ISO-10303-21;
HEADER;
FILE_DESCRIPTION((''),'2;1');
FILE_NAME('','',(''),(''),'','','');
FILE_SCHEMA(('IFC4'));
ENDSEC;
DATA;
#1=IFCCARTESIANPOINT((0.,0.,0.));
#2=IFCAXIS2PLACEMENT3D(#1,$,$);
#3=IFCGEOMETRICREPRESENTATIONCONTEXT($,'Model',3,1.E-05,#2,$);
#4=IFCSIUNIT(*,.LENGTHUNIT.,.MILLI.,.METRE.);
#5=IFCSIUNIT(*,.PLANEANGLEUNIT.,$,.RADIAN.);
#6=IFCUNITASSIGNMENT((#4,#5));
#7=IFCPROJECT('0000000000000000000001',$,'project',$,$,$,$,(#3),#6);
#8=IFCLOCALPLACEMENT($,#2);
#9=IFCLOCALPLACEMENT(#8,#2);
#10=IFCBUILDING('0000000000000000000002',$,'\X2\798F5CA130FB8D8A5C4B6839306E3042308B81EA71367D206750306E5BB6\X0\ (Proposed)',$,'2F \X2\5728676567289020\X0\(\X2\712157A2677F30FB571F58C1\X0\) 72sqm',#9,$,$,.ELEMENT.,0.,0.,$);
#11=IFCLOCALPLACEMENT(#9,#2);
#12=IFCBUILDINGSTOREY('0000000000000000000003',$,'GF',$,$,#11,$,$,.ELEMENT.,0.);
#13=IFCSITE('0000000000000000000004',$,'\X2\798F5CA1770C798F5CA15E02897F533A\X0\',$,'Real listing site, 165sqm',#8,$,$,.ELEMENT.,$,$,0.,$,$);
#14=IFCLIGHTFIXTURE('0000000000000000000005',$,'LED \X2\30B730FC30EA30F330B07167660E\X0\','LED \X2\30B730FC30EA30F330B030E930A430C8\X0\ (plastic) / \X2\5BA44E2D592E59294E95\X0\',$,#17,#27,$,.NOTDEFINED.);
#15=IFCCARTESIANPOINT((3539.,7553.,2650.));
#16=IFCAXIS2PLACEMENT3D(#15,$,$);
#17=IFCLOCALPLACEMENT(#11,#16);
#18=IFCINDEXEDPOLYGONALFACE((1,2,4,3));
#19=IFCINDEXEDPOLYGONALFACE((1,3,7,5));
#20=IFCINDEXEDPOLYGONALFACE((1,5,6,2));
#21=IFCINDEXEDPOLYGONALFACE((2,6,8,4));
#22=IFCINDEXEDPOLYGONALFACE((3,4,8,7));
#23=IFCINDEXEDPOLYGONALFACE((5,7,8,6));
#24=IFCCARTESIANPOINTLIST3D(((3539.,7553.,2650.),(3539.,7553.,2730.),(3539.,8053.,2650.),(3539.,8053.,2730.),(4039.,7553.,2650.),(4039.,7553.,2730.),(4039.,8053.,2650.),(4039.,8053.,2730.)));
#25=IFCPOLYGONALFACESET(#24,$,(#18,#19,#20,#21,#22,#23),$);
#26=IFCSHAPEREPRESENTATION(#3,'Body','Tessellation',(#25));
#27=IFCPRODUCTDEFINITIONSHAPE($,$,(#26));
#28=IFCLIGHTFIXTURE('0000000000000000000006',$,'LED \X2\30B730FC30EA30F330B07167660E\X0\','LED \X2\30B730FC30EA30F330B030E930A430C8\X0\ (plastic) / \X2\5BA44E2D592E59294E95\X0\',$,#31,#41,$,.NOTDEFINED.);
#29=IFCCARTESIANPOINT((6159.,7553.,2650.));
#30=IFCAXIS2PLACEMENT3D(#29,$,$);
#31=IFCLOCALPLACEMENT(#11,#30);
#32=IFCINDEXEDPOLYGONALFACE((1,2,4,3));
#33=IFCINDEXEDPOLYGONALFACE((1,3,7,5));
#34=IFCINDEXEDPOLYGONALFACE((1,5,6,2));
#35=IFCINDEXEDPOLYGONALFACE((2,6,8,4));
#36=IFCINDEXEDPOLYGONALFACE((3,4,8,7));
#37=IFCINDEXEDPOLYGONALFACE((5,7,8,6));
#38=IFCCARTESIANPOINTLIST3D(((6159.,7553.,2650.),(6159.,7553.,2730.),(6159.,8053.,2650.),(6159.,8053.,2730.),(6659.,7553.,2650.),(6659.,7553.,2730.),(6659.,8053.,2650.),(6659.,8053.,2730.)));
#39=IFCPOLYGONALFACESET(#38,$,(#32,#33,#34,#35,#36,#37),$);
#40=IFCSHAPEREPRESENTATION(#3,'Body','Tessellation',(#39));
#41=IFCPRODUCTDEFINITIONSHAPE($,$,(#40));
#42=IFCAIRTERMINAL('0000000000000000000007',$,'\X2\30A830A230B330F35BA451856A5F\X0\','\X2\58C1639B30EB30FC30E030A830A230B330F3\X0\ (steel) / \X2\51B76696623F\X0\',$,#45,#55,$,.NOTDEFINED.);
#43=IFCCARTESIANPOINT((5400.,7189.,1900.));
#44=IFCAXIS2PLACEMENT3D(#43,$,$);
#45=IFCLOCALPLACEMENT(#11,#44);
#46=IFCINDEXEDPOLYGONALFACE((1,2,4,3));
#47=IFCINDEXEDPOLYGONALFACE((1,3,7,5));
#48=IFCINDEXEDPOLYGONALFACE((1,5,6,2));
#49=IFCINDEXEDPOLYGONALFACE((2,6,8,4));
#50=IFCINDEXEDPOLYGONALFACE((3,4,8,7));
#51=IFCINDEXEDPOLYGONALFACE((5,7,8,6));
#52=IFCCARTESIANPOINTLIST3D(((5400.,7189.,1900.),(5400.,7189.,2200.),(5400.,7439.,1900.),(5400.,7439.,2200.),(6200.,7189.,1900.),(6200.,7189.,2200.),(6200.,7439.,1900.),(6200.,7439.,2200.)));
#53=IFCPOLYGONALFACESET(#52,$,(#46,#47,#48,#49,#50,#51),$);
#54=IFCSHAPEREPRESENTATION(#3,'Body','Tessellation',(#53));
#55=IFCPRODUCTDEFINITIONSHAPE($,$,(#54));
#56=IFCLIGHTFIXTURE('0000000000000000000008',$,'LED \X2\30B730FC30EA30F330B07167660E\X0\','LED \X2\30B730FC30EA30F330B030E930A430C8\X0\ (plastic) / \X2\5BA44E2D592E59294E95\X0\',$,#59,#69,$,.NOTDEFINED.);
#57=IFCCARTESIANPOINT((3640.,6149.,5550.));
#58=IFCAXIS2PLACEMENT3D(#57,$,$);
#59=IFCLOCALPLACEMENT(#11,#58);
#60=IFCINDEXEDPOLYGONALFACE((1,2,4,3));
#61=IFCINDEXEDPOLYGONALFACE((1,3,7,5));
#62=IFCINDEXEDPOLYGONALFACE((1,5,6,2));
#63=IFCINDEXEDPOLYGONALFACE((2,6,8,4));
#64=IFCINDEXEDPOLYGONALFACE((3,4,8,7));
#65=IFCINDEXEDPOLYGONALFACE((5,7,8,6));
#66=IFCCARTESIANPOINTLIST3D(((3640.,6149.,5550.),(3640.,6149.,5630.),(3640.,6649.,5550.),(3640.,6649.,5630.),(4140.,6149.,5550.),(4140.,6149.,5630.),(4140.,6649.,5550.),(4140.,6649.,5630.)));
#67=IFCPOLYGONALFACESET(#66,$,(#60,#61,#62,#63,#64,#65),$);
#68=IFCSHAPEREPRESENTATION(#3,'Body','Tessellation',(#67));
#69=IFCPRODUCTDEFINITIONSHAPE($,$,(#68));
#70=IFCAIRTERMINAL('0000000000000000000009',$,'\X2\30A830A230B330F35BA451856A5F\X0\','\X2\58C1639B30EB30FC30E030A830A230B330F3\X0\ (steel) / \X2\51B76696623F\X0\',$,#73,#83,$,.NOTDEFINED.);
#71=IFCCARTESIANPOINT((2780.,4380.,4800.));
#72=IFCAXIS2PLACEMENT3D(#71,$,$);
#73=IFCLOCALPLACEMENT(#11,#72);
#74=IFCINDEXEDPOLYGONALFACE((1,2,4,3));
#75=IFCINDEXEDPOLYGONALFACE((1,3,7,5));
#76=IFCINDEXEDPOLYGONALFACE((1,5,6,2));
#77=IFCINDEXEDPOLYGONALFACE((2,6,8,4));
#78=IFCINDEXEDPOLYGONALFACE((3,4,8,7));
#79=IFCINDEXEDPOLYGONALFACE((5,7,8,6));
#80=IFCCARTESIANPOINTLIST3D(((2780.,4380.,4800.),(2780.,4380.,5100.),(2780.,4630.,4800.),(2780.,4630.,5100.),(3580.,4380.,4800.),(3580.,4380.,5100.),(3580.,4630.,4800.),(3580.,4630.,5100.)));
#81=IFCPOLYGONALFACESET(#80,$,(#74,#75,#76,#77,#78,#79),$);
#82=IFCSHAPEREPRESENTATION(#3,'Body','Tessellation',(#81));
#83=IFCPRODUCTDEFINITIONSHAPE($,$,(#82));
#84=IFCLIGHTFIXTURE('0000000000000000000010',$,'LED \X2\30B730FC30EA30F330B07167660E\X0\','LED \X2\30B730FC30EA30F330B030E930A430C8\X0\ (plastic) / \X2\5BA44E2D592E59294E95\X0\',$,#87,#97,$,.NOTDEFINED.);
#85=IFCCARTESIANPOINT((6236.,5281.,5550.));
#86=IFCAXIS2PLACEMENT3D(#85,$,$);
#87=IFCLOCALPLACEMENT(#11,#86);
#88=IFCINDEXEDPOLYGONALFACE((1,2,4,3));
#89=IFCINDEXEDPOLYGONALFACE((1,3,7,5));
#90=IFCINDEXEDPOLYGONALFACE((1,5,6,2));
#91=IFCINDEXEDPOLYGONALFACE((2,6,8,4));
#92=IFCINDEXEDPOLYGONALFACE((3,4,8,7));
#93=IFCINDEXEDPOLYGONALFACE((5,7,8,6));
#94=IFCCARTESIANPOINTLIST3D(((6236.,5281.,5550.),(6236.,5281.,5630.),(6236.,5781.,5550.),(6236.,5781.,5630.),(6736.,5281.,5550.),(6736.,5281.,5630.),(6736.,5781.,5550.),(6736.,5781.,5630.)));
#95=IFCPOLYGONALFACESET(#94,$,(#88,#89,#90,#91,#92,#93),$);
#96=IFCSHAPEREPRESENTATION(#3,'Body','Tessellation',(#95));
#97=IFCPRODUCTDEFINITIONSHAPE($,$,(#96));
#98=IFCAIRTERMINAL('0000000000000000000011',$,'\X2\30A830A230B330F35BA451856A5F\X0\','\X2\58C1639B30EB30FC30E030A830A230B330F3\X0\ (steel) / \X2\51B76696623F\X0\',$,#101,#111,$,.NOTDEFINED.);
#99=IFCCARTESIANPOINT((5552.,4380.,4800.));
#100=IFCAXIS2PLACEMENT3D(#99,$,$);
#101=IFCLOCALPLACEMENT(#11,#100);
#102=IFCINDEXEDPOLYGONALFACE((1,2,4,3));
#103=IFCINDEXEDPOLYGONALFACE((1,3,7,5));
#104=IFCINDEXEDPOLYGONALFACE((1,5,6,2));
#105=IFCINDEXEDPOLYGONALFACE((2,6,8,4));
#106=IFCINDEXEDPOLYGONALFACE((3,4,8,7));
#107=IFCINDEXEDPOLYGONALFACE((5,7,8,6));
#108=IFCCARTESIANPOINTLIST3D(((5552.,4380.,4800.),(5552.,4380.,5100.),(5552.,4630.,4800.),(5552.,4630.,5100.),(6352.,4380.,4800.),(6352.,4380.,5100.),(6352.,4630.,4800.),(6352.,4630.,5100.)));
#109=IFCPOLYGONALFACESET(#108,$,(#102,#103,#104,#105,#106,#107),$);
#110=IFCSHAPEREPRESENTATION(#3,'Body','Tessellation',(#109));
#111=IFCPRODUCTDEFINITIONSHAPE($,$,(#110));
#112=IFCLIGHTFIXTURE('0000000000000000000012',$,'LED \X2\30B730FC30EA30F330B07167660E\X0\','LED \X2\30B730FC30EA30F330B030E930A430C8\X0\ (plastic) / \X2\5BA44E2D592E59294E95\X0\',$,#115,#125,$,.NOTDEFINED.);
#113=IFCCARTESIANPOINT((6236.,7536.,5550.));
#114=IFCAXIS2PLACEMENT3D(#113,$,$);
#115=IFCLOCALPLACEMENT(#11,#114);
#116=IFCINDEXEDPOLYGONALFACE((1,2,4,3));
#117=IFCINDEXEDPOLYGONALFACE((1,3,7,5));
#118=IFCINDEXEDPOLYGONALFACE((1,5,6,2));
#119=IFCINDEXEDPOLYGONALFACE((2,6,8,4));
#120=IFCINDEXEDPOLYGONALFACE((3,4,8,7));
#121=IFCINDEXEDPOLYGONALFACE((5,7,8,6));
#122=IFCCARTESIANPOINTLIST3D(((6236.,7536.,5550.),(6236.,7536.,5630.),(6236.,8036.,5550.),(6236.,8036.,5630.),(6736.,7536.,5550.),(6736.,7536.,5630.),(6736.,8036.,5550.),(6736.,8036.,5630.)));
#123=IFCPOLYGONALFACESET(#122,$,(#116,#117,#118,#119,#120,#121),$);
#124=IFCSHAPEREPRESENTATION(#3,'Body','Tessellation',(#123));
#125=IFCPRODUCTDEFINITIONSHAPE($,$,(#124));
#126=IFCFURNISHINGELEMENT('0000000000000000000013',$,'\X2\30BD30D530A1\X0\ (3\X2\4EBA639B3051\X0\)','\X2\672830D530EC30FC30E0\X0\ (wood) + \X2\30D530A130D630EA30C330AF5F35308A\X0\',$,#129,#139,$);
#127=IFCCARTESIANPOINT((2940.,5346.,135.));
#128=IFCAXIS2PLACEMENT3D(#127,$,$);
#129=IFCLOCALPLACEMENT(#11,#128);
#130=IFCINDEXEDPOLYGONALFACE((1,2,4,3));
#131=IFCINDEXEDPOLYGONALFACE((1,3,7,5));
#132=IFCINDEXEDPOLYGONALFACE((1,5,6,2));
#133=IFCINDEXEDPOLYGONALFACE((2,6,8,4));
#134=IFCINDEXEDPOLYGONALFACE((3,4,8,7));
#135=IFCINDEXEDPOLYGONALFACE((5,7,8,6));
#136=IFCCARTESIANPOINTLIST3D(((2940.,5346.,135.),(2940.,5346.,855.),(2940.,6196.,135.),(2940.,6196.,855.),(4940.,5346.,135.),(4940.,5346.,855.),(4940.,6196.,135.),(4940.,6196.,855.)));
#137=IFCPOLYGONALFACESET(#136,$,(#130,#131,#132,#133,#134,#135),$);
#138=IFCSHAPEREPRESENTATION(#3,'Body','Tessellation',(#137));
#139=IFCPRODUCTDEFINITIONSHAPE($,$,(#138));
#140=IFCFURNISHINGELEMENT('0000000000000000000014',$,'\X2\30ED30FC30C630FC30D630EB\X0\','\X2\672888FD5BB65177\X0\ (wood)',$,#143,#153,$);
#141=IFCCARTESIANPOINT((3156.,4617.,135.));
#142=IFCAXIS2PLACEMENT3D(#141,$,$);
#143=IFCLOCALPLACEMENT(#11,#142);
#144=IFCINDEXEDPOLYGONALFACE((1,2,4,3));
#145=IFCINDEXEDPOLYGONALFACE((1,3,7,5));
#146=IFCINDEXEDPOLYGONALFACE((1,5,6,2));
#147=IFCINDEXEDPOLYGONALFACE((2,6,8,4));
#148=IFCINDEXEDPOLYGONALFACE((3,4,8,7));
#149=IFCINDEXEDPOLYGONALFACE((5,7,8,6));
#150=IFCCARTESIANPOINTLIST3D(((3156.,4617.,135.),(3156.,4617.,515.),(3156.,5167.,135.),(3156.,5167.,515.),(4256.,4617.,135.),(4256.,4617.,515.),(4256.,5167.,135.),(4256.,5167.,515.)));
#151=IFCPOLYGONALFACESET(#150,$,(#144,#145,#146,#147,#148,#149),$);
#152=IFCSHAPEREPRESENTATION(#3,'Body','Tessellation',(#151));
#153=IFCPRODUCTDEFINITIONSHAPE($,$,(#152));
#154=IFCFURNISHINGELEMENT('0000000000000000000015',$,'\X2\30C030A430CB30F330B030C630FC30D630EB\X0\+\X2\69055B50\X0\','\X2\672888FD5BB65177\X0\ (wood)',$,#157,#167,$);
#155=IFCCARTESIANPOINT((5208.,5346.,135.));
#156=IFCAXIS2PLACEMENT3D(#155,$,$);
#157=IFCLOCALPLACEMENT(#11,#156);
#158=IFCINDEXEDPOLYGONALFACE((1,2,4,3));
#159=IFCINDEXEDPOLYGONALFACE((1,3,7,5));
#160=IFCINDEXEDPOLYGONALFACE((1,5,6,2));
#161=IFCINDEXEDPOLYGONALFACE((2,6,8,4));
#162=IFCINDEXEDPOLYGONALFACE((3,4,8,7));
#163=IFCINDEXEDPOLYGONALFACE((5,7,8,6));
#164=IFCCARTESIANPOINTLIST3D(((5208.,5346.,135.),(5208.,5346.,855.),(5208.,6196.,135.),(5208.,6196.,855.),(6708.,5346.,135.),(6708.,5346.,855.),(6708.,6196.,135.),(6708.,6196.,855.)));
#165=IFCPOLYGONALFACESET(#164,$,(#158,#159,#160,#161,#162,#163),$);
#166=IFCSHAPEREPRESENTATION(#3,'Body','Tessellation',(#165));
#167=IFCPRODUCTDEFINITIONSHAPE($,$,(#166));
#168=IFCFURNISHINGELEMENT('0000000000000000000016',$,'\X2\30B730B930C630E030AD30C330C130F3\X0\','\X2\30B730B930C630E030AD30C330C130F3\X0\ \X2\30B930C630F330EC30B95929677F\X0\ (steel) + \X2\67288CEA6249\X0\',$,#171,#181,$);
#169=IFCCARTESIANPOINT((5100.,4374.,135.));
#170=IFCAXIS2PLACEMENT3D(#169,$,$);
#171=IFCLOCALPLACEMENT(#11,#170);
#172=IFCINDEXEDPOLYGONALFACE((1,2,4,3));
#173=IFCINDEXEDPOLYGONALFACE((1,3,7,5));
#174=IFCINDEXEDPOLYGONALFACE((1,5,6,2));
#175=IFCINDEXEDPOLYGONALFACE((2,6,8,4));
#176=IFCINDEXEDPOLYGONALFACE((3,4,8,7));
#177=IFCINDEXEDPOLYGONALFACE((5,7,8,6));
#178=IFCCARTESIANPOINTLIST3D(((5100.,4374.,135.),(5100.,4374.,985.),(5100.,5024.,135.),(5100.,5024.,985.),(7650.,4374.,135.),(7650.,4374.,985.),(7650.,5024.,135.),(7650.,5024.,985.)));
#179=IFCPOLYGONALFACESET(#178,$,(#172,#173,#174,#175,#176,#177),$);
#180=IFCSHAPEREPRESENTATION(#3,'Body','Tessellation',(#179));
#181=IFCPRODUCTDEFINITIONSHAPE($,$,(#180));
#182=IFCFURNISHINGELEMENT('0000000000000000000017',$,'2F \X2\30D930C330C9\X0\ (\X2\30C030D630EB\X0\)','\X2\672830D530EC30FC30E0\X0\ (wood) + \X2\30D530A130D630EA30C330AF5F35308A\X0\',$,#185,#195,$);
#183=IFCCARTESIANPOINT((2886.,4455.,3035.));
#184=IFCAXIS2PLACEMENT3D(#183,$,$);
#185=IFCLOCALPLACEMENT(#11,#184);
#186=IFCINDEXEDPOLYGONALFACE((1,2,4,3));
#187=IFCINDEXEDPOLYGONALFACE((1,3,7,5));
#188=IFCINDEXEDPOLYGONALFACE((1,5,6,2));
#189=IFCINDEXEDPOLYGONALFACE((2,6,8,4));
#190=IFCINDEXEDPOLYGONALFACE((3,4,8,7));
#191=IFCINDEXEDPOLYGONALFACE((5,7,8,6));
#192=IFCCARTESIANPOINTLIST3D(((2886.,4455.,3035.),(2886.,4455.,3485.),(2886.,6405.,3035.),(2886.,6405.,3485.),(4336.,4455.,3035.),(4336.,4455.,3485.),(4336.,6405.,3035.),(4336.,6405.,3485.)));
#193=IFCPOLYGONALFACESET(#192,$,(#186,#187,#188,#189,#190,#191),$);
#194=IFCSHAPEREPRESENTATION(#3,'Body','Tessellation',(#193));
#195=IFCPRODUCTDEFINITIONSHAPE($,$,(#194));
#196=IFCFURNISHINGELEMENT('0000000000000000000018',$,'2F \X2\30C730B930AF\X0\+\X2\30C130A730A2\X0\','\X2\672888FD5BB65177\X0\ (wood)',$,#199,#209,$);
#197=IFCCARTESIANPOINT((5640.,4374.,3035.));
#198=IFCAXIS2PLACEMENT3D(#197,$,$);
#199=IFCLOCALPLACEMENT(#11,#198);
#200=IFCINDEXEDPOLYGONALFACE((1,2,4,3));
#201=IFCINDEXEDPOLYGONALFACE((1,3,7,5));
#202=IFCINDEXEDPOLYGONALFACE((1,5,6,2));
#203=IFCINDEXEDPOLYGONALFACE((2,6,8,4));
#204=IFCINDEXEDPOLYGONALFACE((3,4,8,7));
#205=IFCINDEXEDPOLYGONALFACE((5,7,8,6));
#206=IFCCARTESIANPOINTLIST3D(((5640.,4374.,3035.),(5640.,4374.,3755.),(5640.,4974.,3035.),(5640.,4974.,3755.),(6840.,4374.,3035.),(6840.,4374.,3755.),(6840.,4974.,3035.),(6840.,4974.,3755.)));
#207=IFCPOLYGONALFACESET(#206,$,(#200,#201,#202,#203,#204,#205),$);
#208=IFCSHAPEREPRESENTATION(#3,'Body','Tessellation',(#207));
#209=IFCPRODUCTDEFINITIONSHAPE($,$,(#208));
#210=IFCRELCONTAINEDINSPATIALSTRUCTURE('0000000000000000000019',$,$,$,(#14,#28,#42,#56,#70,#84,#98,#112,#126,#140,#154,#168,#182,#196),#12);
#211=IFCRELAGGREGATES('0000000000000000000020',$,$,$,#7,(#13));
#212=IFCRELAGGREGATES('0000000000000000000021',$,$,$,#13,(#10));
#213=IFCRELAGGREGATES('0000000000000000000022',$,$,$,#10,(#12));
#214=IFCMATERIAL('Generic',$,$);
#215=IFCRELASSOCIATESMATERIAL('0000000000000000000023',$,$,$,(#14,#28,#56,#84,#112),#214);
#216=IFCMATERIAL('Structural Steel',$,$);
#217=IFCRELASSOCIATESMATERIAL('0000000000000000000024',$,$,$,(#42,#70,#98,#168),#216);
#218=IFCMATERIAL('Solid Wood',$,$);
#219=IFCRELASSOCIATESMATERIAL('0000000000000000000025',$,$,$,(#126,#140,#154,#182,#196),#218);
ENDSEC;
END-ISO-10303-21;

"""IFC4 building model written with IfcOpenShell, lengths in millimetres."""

from ifc_helpers import new_model, si_unit, frame, frame_2d, origin, place, context, project, spatial, rectangle, extrude, material, element, save


model = new_model("IFC4")

# Units and contexts
model_context = context("Model", 3, precision=1e-05, world=origin())
ifc_project = project(units=[si_unit("LENGTHUNIT", "METRE", prefix="MILLI"), si_unit("PLANEANGLEUNIT", "RADIAN")], contexts=[model_context])

# Site, building, storey
site_placement = place(None, origin())
site = spatial("IfcSite", under=ifc_project, at=site_placement, Name="福岡県福岡市西区", ObjectType="Real listing site, 165sqm", CompositionType="ELEMENT", RefElevation=0.0)
building_placement = place(site_placement, origin())
building = spatial("IfcBuilding", under=site, at=building_placement, Name="福岡・越屋根のある自然素材の家 (Proposed)", ObjectType="2F 在来木造(無垢板・土壁) 72sqm", CompositionType="ELEMENT", ElevationOfRefHeight=0.0, ElevationOfTerrain=0.0)
storey_placement = place(building_placement, origin())
storey = spatial("IfcBuildingStorey", under=building, at=storey_placement, Name="GF", CompositionType="ELEMENT", Elevation=0.0)

# Shared definitions
ifc_material_1 = material(Name="Solid Wood")

# Shared definitions
ifc_material_2 = material(Name="Structural Steel")

# Shared definitions
ifc_material_3 = material(Name="Generic")

# Light fixtures
light_fixture_1_placement = place(storey_placement, frame((3539.0, 7553.0, 2650.0)))
element("IfcLightFixture", 1, at=light_fixture_1_placement, inside=storey, material=ifc_material_3, Name="LED シーリング照明", Description="LED シーリングライト (plastic) / 室中央天井", PredefinedType="NOTDEFINED", context=model_context, shape_type="SweptSolid", body=[
    extrude(rectangle(XDim=500.0, YDim=500.0, at=frame_2d((250.0, 250.0))), frame((3539.0, 7553.0, 2650.0)), (0.0, 0.0, 1.0), 80.0),
])
light_fixture_2_placement = place(storey_placement, frame((6159.0, 7553.0, 2650.0)))
element("IfcLightFixture", 2, at=light_fixture_2_placement, inside=storey, material=ifc_material_3, Name="LED シーリング照明", Description="LED シーリングライト (plastic) / 室中央天井", PredefinedType="NOTDEFINED", context=model_context, shape_type="SweptSolid", body=[
    extrude(rectangle(XDim=500.0, YDim=500.0, at=frame_2d((250.0, 250.0))), frame((6159.0, 7553.0, 2650.0)), (0.0, 0.0, 1.0), 80.0),
])

# Air terminal
air_terminal_1_placement = place(storey_placement, frame((5400.0, 7189.0, 1900.0)))
element("IfcAirTerminal", 3, at=air_terminal_1_placement, inside=storey, material=ifc_material_2, Name="エアコン室内機", Description="壁掛ルームエアコン (steel) / 冷暖房", PredefinedType="NOTDEFINED", context=model_context, shape_type="SweptSolid", body=[
    extrude(rectangle(XDim=800.0, YDim=250.0, at=frame_2d((400.0, 125.0))), frame((5400.0, 7189.0, 1900.0)), (0.0, 0.0, 1.0), 300.0),
])

# Light fixture
light_fixture_3_placement = place(storey_placement, frame((3640.0, 6149.0, 5550.0)))
element("IfcLightFixture", 4, at=light_fixture_3_placement, inside=storey, material=ifc_material_3, Name="LED シーリング照明", Description="LED シーリングライト (plastic) / 室中央天井", PredefinedType="NOTDEFINED", context=model_context, shape_type="SweptSolid", body=[
    extrude(rectangle(XDim=500.0, YDim=500.0, at=frame_2d((250.0, 250.0))), frame((3640.0, 6149.0, 5550.0)), (0.0, 0.0, 1.0), 80.0),
])

# Air terminal
air_terminal_2_placement = place(storey_placement, frame((2780.0, 4380.0, 4800.0)))
element("IfcAirTerminal", 5, at=air_terminal_2_placement, inside=storey, material=ifc_material_2, Name="エアコン室内機", Description="壁掛ルームエアコン (steel) / 冷暖房", PredefinedType="NOTDEFINED", context=model_context, shape_type="SweptSolid", body=[
    extrude(rectangle(XDim=800.0, YDim=250.0, at=frame_2d((400.0, 125.0))), frame((2780.0, 4380.0, 4800.0)), (0.0, 0.0, 1.0), 300.0),
])

# Light fixture
light_fixture_4_placement = place(storey_placement, frame((6236.0, 5281.0, 5550.0)))
element("IfcLightFixture", 6, at=light_fixture_4_placement, inside=storey, material=ifc_material_3, Name="LED シーリング照明", Description="LED シーリングライト (plastic) / 室中央天井", PredefinedType="NOTDEFINED", context=model_context, shape_type="SweptSolid", body=[
    extrude(rectangle(XDim=500.0, YDim=500.0, at=frame_2d((250.0, 250.0))), frame((6236.0, 5281.0, 5550.0)), (0.0, 0.0, 1.0), 80.0),
])

# Air terminal
air_terminal_3_placement = place(storey_placement, frame((5552.0, 4380.0, 4800.0)))
element("IfcAirTerminal", 7, at=air_terminal_3_placement, inside=storey, material=ifc_material_2, Name="エアコン室内機", Description="壁掛ルームエアコン (steel) / 冷暖房", PredefinedType="NOTDEFINED", context=model_context, shape_type="SweptSolid", body=[
    extrude(rectangle(XDim=800.0, YDim=250.0, at=frame_2d((400.0, 125.0))), frame((5552.0, 4380.0, 4800.0)), (0.0, 0.0, 1.0), 300.0),
])

# Light fixture
light_fixture_5_placement = place(storey_placement, frame((6236.0, 7536.0, 5550.0)))
element("IfcLightFixture", 8, at=light_fixture_5_placement, inside=storey, material=ifc_material_3, Name="LED シーリング照明", Description="LED シーリングライト (plastic) / 室中央天井", PredefinedType="NOTDEFINED", context=model_context, shape_type="SweptSolid", body=[
    extrude(rectangle(XDim=500.0, YDim=500.0, at=frame_2d((250.0, 250.0))), frame((6236.0, 7536.0, 5550.0)), (0.0, 0.0, 1.0), 80.0),
])

# Furnishing elements
furnishing_1_placement = place(storey_placement, frame((2940.0, 5346.0, 135.0)))
element("IfcFurnishingElement", 9, at=furnishing_1_placement, inside=storey, material=ifc_material_1, Name="ソファ (3人掛け)", Description="木フレーム (wood) + ファブリック張り", context=model_context, shape_type="SweptSolid", body=[
    extrude(rectangle(XDim=2000.0, YDim=850.0, at=frame_2d((1000.0, 425.0))), frame((2940.0, 5346.0, 135.0)), (0.0, 0.0, 1.0), 720.0),
])
furnishing_2_placement = place(storey_placement, frame((3156.0, 4617.0, 135.0)))
element("IfcFurnishingElement", 10, at=furnishing_2_placement, inside=storey, material=ifc_material_1, Name="ローテーブル", Description="木製家具 (wood)", context=model_context, shape_type="SweptSolid", body=[
    extrude(rectangle(XDim=1100.0, YDim=550.0, at=frame_2d((550.0, 275.0))), frame((3156.0, 4617.0, 135.0)), (0.0, 0.0, 1.0), 380.0),
])
furnishing_3_placement = place(storey_placement, frame((5208.0, 5346.0, 135.0)))
element("IfcFurnishingElement", 11, at=furnishing_3_placement, inside=storey, material=ifc_material_1, Name="ダイニングテーブル+椅子", Description="木製家具 (wood)", context=model_context, shape_type="SweptSolid", body=[
    extrude(rectangle(XDim=1500.0, YDim=850.0, at=frame_2d((750.0, 425.0))), frame((5208.0, 5346.0, 135.0)), (0.0, 0.0, 1.0), 720.0),
])
furnishing_4_placement = place(storey_placement, frame((5100.0, 4374.0, 135.0)))
element("IfcFurnishingElement", 12, at=furnishing_4_placement, inside=storey, material=ifc_material_2, Name="システムキッチン", Description="システムキッチン ステンレス天板 (steel) + 木質扉", context=model_context, shape_type="SweptSolid", body=[
    extrude(rectangle(XDim=2550.0, YDim=650.0, at=frame_2d((1275.0, 325.0))), frame((5100.0, 4374.0, 135.0)), (0.0, 0.0, 1.0), 850.0),
])
furnishing_5_placement = place(storey_placement, frame((2886.0, 4455.0, 3035.0)))
element("IfcFurnishingElement", 13, at=furnishing_5_placement, inside=storey, material=ifc_material_1, Name="2F ベッド (ダブル)", Description="木フレーム (wood) + ファブリック張り", context=model_context, shape_type="SweptSolid", body=[
    extrude(rectangle(XDim=1450.0, YDim=1950.0, at=frame_2d((725.0, 975.0))), frame((2886.0, 4455.0, 3035.0)), (0.0, 0.0, 1.0), 450.0),
])
furnishing_6_placement = place(storey_placement, frame((5640.0, 4374.0, 3035.0)))
element("IfcFurnishingElement", 14, at=furnishing_6_placement, inside=storey, material=ifc_material_1, Name="2F デスク+チェア", Description="木製家具 (wood)", context=model_context, shape_type="SweptSolid", body=[
    extrude(rectangle(XDim=1200.0, YDim=600.0, at=frame_2d((600.0, 300.0))), frame((5640.0, 4374.0, 3035.0)), (0.0, 0.0, 1.0), 720.0),
])

save(model, "model.ifc")
